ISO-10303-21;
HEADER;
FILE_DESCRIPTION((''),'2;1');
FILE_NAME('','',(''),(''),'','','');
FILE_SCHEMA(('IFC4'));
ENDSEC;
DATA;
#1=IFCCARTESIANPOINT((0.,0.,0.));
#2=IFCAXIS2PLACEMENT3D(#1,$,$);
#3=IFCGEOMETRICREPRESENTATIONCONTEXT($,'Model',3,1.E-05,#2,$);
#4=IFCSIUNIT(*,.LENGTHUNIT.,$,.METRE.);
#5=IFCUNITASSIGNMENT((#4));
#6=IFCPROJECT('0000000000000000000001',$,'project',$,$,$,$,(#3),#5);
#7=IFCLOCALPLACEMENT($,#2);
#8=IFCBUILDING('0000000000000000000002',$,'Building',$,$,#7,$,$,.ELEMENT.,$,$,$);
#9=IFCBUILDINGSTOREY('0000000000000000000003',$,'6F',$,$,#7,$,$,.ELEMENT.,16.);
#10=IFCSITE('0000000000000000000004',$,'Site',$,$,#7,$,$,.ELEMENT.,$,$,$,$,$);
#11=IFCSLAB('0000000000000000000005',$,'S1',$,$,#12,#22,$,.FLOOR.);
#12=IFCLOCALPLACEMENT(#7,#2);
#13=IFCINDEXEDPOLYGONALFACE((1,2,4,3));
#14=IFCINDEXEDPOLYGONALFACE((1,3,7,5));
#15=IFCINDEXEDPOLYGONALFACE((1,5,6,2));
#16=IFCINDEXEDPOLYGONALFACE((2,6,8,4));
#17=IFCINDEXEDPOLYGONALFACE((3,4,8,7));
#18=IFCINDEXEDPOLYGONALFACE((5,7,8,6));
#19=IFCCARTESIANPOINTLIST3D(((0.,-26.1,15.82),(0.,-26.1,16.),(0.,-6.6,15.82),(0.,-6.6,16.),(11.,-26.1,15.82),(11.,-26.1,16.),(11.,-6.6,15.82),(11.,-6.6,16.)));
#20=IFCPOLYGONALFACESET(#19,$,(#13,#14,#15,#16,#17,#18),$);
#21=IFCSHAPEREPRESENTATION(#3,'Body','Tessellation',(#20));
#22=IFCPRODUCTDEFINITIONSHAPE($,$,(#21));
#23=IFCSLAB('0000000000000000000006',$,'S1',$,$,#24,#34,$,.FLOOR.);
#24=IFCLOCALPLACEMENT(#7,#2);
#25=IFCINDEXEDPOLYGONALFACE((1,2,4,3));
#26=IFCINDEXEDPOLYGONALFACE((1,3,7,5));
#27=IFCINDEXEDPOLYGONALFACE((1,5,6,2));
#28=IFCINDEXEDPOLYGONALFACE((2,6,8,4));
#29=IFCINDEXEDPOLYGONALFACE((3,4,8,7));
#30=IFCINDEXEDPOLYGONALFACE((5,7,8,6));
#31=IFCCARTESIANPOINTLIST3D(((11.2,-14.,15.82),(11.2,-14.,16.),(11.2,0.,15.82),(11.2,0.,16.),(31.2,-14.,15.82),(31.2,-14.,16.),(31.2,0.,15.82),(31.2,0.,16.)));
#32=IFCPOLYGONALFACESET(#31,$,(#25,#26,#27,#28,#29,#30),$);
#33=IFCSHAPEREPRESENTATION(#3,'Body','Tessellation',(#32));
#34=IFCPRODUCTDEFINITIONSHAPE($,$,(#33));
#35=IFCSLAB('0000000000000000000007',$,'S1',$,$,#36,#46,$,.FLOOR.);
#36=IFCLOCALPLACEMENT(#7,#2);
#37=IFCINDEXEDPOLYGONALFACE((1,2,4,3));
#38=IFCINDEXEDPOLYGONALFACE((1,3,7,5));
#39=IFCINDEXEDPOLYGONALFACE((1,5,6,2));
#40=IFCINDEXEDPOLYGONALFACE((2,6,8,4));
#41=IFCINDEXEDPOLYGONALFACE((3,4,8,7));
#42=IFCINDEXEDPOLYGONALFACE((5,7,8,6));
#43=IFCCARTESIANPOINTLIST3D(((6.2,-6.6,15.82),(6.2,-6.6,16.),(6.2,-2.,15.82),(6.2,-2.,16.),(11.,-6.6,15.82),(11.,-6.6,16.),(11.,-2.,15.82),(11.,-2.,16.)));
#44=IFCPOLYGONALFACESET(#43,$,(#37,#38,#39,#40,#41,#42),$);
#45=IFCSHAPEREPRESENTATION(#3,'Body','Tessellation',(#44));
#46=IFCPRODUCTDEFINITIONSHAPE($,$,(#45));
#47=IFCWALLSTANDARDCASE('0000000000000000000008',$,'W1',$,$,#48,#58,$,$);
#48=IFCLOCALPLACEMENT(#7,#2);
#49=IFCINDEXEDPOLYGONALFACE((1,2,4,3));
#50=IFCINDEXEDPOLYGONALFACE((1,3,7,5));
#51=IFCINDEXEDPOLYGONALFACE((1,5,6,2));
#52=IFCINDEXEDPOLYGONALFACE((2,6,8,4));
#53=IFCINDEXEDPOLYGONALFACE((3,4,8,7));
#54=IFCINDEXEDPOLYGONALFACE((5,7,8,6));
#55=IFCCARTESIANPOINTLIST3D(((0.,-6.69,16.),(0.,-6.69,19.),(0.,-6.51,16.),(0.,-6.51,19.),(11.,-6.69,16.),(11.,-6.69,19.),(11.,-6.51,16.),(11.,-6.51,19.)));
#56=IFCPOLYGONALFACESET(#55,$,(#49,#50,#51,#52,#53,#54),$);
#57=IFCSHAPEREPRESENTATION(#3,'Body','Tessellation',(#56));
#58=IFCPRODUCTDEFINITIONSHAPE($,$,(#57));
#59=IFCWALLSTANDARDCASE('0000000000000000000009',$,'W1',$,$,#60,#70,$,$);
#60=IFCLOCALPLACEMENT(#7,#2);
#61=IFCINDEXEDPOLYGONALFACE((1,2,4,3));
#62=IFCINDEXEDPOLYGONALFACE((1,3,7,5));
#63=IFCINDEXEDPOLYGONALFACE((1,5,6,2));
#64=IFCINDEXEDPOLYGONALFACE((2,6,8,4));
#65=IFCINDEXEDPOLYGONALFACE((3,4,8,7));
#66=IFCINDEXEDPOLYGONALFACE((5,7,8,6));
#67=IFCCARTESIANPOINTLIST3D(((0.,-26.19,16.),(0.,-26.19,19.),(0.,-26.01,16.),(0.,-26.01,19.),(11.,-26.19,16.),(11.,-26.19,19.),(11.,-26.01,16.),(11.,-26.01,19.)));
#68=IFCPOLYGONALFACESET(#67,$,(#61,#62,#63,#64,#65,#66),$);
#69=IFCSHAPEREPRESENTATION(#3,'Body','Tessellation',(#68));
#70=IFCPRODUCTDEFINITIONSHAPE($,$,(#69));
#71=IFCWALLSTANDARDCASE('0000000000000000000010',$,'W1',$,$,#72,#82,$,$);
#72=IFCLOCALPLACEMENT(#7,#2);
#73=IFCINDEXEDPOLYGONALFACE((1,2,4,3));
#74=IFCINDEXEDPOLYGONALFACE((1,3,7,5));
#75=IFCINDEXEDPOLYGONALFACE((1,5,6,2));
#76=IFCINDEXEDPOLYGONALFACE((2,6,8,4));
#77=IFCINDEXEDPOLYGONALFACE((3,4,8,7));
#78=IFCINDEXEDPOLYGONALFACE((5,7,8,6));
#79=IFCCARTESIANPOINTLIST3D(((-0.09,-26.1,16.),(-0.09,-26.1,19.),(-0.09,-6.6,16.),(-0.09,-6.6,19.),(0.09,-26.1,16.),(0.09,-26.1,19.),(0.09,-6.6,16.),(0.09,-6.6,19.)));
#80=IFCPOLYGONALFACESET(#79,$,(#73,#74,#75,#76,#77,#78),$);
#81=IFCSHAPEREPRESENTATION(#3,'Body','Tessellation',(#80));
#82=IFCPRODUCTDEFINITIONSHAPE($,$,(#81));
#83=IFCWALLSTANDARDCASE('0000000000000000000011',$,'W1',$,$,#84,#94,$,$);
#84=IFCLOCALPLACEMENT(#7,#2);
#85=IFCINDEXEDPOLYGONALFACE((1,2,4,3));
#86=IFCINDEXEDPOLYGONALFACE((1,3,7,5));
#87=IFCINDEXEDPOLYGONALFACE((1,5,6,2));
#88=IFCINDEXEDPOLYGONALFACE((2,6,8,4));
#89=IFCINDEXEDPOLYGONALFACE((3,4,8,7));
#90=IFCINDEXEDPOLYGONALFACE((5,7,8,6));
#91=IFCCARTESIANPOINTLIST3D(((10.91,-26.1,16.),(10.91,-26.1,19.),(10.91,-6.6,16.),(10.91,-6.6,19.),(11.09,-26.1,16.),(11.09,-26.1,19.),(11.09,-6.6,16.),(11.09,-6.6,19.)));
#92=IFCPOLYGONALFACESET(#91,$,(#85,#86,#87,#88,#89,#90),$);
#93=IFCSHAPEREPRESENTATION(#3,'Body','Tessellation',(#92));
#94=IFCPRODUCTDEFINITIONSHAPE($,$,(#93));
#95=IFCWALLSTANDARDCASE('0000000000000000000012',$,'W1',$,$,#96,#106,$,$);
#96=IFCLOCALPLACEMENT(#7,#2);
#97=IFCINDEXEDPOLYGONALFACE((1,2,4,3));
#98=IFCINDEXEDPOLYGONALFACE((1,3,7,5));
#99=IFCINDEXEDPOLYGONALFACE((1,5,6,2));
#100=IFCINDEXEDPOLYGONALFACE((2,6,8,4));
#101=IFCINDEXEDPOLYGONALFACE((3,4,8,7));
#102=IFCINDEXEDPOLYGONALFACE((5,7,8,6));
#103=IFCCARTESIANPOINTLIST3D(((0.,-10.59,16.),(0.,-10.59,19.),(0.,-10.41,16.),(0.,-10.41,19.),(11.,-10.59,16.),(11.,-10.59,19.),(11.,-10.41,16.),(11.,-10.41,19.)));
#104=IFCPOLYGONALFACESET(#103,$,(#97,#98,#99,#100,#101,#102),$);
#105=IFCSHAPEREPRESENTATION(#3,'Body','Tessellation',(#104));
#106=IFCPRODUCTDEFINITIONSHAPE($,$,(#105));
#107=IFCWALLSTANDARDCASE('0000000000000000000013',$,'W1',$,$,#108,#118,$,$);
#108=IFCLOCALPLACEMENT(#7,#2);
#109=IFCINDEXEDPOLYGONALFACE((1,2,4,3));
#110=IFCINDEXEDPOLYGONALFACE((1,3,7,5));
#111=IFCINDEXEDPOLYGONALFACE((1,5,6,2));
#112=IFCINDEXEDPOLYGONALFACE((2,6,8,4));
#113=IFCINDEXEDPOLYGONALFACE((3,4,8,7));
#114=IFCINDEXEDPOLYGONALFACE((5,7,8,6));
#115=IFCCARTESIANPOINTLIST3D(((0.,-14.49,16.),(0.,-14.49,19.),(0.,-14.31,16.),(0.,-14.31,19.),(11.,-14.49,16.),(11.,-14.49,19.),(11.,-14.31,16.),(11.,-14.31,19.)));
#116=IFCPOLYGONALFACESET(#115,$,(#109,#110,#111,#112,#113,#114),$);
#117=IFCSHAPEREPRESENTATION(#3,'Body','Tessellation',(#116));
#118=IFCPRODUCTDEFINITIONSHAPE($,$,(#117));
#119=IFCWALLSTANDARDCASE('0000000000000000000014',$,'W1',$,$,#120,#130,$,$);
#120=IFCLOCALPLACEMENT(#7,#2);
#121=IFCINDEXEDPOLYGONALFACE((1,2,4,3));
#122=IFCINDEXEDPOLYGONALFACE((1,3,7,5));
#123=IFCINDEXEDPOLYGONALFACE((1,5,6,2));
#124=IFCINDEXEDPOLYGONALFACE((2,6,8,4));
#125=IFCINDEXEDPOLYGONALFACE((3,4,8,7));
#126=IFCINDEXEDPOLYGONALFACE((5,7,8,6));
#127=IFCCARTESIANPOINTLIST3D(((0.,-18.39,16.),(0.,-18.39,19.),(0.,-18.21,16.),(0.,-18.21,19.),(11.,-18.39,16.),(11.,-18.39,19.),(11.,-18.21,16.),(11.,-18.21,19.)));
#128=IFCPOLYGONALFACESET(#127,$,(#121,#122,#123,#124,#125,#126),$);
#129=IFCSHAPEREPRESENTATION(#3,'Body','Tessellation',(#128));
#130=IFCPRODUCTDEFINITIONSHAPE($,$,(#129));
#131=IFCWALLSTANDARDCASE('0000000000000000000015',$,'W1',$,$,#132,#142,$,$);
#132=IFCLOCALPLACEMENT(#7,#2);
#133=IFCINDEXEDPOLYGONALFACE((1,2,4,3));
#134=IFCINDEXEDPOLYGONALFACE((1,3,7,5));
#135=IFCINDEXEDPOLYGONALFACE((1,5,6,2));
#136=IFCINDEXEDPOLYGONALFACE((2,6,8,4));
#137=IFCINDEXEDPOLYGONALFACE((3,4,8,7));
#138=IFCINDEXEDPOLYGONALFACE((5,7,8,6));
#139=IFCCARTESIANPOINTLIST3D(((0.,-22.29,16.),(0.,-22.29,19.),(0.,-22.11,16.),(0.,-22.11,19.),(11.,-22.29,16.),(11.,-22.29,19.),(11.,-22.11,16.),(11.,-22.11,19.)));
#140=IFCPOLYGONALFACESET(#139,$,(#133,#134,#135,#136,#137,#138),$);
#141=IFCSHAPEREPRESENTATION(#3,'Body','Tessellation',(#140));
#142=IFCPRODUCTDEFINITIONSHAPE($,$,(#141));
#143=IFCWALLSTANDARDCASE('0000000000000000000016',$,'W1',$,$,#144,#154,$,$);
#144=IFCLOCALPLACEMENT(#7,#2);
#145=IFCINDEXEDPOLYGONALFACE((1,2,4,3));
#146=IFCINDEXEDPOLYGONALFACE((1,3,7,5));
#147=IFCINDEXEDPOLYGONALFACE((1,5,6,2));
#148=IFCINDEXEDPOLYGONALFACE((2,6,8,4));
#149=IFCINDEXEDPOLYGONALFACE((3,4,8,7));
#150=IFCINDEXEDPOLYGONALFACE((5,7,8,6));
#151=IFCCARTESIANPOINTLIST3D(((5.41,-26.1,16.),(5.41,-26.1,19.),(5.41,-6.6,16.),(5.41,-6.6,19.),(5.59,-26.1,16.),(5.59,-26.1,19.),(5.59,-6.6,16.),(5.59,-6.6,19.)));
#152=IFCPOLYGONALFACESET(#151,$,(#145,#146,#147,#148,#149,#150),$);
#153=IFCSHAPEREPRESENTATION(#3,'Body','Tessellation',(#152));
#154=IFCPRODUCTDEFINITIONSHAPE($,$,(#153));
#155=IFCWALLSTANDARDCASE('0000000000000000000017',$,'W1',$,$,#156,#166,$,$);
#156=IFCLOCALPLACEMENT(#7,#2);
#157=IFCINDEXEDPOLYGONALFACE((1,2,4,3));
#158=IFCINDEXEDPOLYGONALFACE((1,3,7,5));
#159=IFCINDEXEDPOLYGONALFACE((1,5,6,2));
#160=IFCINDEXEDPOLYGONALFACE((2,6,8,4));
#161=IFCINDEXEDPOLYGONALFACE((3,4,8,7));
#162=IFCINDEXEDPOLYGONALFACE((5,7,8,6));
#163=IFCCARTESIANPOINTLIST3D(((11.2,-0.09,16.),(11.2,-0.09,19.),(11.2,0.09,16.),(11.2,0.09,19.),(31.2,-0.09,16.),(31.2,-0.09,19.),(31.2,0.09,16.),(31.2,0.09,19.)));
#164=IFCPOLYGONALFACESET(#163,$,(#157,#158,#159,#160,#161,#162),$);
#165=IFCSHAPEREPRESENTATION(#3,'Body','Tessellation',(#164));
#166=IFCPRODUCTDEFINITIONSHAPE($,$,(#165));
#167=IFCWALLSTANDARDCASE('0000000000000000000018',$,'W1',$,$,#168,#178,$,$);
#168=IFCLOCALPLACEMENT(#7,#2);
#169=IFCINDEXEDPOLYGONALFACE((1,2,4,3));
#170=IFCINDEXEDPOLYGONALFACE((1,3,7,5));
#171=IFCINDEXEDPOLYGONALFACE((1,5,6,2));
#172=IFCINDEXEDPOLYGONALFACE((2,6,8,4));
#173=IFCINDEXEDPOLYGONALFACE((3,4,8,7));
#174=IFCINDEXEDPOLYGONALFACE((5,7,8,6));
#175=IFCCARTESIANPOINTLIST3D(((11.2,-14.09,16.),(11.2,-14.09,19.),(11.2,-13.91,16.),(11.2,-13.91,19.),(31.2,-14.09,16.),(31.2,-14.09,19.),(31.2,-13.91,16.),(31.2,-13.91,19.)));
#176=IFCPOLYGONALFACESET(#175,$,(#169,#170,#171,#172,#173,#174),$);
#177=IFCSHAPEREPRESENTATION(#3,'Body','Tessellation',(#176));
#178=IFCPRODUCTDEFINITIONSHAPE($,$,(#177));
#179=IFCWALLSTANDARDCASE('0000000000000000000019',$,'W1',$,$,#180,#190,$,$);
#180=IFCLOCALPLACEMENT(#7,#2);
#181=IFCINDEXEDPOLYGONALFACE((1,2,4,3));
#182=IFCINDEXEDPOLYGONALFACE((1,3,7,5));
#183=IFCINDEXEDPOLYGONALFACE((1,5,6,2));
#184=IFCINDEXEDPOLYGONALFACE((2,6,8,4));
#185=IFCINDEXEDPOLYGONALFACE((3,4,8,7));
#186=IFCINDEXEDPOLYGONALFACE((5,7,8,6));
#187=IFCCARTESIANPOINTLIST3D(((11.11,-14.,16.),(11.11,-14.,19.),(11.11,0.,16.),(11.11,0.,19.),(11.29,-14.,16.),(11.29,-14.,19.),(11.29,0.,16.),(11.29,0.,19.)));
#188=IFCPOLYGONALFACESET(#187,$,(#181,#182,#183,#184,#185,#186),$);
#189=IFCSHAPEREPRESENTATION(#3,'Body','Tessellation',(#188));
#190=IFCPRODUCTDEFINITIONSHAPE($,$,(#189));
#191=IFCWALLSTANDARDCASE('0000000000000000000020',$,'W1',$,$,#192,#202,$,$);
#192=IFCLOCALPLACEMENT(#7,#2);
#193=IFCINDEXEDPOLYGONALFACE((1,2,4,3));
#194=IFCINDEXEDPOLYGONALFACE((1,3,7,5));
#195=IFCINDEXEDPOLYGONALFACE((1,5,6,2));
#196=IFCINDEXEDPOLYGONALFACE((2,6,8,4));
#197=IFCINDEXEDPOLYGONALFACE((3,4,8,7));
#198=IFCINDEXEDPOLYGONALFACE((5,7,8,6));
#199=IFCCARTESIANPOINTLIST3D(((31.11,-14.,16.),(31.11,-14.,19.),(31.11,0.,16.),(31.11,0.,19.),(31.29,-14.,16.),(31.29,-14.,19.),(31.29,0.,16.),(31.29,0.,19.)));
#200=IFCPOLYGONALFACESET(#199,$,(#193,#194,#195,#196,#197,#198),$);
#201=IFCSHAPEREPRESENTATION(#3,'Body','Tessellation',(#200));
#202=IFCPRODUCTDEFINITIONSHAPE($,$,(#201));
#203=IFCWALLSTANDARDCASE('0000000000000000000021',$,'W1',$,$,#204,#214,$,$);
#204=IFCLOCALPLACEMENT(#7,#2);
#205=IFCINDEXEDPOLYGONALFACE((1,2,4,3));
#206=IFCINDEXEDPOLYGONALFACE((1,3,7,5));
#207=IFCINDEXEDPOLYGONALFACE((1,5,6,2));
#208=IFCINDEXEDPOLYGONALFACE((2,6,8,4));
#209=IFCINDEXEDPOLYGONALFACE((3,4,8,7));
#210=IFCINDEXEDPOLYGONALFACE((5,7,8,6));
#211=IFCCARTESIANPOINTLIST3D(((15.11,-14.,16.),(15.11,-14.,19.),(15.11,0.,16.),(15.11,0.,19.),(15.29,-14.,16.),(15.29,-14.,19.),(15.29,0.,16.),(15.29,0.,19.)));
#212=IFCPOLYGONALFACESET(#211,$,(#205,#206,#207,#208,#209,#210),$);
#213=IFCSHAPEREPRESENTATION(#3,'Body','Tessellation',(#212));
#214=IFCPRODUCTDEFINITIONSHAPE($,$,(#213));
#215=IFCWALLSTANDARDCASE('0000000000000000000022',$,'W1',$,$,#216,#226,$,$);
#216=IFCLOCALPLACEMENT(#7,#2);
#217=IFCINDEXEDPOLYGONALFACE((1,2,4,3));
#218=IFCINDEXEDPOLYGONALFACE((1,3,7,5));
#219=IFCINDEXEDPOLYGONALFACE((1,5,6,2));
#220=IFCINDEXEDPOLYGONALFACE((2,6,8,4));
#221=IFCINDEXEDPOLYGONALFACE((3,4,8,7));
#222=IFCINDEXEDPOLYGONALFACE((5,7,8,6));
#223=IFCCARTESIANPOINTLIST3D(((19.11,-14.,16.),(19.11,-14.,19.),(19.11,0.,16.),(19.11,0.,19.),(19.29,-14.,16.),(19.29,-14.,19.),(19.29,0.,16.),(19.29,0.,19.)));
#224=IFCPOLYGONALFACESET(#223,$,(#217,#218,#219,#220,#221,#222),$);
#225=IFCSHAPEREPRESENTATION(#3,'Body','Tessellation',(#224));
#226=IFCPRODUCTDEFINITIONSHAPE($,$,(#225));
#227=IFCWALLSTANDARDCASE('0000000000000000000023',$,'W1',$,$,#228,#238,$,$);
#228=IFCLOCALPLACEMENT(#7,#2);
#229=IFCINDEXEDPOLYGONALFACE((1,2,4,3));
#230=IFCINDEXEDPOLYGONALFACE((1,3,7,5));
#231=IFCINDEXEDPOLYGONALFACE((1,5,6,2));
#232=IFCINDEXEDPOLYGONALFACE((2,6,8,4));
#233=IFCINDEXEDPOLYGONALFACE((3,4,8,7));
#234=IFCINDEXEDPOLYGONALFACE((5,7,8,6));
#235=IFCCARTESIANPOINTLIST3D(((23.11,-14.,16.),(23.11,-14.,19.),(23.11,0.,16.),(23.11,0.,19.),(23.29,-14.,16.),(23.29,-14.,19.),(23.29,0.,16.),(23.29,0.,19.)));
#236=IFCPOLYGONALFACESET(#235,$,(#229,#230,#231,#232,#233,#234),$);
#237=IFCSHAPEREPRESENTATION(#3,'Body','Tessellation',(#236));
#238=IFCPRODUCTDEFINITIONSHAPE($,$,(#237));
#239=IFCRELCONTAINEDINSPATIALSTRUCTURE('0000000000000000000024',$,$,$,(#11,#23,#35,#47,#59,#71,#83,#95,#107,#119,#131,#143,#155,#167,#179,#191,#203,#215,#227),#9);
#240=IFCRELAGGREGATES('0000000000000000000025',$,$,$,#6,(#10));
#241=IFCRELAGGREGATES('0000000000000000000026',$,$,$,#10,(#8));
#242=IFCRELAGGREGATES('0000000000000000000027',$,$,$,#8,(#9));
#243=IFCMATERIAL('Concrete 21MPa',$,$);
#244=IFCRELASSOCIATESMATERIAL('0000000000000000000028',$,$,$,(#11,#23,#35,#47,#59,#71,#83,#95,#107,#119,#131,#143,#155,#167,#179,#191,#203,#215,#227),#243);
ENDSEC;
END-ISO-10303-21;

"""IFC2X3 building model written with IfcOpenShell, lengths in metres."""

from ifc_helpers import new_model, si_unit, frame, origin, origin_2d, place, context, project, spatial, rectangle, extrude, material, element, save


model = new_model("IFC2X3")

# Units and contexts
model_context = context("Model", 3, precision=1e-05, world=origin())
ifc_project = project(units=[si_unit("LENGTHUNIT", "METRE")], contexts=[model_context])

# Site, building, storey
placement = place(None, origin())
site = spatial("IfcSite", under=ifc_project, at=placement, Name="Site", CompositionType="ELEMENT")
building = spatial("IfcBuilding", under=site, at=placement, Name="Building", CompositionType="ELEMENT")
storey = spatial("IfcBuildingStorey", under=building, at=placement, Name="6F", CompositionType="ELEMENT", Elevation=16.0)

# Slabs
ifc_material_1 = material(Name="Concrete 21MPa")
slab_1_placement = place(None, frame((5.5, -16.35, 15.82)))
element("IfcSlab", 1, at=slab_1_placement, inside=storey, material=ifc_material_1, Name="S1", PredefinedType="FLOOR", context=model_context, shape_type="SweptSolid", body=[
    extrude(rectangle(XDim=11.0, YDim=19.5, at=origin_2d()), origin(), (0.0, 0.0, 1.0), 0.18),
])
slab_2_placement = place(None, frame((21.2, -7.0, 15.82)))
element("IfcSlab", 2, at=slab_2_placement, inside=storey, material=ifc_material_1, Name="S1", PredefinedType="FLOOR", context=model_context, shape_type="SweptSolid", body=[
    extrude(rectangle(XDim=20.0, YDim=14.0, at=origin_2d()), origin(), (0.0, 0.0, 1.0), 0.18),
])
slab_3_placement = place(None, frame((8.6, -4.3, 15.82)))
element("IfcSlab", 3, at=slab_3_placement, inside=storey, material=ifc_material_1, Name="S1", PredefinedType="FLOOR", context=model_context, shape_type="SweptSolid", body=[
    extrude(rectangle(XDim=4.8, YDim=4.6, at=origin_2d()), origin(), (0.0, 0.0, 1.0), 0.18),
])

# Walls
for number, where, name in (
    (4, (5.5, -6.6, 16.0), "W1"),
    (5, (5.5, -26.1, 16.0), "W1"),
):
    element("IfcWallStandardCase", number, at=place(None, frame(where)), inside=storey, material=ifc_material_1, Name=name, context=model_context, shape_type="SweptSolid", body=[
        extrude(rectangle(XDim=11.0, YDim=0.18, at=origin_2d()), origin(), (0.0, 0.0, 1.0), 3.0),
    ])
for number, where, name in (
    (6, (0.0, -16.35, 16.0), "W1"),
    (7, (11.0, -16.35, 16.0), "W1"),
):
    element("IfcWallStandardCase", number, at=place(None, frame(where)), inside=storey, material=ifc_material_1, Name=name, context=model_context, shape_type="SweptSolid", body=[
        extrude(rectangle(XDim=0.18, YDim=19.5, at=origin_2d()), origin(), (0.0, 0.0, 1.0), 3.0),
    ])
for number, where, name in (
    (8, (5.5, -10.5, 16.0), "W1"),
    (9, (5.5, -14.4, 16.0), "W1"),
    (10, (5.5, -18.3, 16.0), "W1"),
    (11, (5.5, -22.2, 16.0), "W1"),
):
    element("IfcWallStandardCase", number, at=place(None, frame(where)), inside=storey, material=ifc_material_1, Name=name, context=model_context, shape_type="SweptSolid", body=[
        extrude(rectangle(XDim=11.0, YDim=0.18, at=origin_2d()), origin(), (0.0, 0.0, 1.0), 3.0),
    ])
wall_1_placement = place(None, frame((5.5, -16.35, 16.0)))
element("IfcWallStandardCase", 12, at=wall_1_placement, inside=storey, material=ifc_material_1, Name="W1", context=model_context, shape_type="SweptSolid", body=[
    extrude(rectangle(XDim=0.18, YDim=19.5, at=origin_2d()), origin(), (0.0, 0.0, 1.0), 3.0),
])
for number, where, name in (
    (13, (21.2, 0.0, 16.0), "W1"),
    (14, (21.2, -14.0, 16.0), "W1"),
):
    element("IfcWallStandardCase", number, at=place(None, frame(where)), inside=storey, material=ifc_material_1, Name=name, context=model_context, shape_type="SweptSolid", body=[
        extrude(rectangle(XDim=20.0, YDim=0.18, at=origin_2d()), origin(), (0.0, 0.0, 1.0), 3.0),
    ])
for number, where, name in (
    (15, (11.2, -7.0, 16.0), "W1"),
    (16, (31.2, -7.0, 16.0), "W1"),
    (17, (15.2, -7.0, 16.0), "W1"),
    (18, (19.2, -7.0, 16.0), "W1"),
    (19, (23.2, -7.0, 16.0), "W1"),
):
    element("IfcWallStandardCase", number, at=place(None, frame(where)), inside=storey, material=ifc_material_1, Name=name, context=model_context, shape_type="SweptSolid", body=[
        extrude(rectangle(XDim=0.18, YDim=14.0, at=origin_2d()), origin(), (0.0, 0.0, 1.0), 3.0),
    ])

save(model, "model.ifc")
